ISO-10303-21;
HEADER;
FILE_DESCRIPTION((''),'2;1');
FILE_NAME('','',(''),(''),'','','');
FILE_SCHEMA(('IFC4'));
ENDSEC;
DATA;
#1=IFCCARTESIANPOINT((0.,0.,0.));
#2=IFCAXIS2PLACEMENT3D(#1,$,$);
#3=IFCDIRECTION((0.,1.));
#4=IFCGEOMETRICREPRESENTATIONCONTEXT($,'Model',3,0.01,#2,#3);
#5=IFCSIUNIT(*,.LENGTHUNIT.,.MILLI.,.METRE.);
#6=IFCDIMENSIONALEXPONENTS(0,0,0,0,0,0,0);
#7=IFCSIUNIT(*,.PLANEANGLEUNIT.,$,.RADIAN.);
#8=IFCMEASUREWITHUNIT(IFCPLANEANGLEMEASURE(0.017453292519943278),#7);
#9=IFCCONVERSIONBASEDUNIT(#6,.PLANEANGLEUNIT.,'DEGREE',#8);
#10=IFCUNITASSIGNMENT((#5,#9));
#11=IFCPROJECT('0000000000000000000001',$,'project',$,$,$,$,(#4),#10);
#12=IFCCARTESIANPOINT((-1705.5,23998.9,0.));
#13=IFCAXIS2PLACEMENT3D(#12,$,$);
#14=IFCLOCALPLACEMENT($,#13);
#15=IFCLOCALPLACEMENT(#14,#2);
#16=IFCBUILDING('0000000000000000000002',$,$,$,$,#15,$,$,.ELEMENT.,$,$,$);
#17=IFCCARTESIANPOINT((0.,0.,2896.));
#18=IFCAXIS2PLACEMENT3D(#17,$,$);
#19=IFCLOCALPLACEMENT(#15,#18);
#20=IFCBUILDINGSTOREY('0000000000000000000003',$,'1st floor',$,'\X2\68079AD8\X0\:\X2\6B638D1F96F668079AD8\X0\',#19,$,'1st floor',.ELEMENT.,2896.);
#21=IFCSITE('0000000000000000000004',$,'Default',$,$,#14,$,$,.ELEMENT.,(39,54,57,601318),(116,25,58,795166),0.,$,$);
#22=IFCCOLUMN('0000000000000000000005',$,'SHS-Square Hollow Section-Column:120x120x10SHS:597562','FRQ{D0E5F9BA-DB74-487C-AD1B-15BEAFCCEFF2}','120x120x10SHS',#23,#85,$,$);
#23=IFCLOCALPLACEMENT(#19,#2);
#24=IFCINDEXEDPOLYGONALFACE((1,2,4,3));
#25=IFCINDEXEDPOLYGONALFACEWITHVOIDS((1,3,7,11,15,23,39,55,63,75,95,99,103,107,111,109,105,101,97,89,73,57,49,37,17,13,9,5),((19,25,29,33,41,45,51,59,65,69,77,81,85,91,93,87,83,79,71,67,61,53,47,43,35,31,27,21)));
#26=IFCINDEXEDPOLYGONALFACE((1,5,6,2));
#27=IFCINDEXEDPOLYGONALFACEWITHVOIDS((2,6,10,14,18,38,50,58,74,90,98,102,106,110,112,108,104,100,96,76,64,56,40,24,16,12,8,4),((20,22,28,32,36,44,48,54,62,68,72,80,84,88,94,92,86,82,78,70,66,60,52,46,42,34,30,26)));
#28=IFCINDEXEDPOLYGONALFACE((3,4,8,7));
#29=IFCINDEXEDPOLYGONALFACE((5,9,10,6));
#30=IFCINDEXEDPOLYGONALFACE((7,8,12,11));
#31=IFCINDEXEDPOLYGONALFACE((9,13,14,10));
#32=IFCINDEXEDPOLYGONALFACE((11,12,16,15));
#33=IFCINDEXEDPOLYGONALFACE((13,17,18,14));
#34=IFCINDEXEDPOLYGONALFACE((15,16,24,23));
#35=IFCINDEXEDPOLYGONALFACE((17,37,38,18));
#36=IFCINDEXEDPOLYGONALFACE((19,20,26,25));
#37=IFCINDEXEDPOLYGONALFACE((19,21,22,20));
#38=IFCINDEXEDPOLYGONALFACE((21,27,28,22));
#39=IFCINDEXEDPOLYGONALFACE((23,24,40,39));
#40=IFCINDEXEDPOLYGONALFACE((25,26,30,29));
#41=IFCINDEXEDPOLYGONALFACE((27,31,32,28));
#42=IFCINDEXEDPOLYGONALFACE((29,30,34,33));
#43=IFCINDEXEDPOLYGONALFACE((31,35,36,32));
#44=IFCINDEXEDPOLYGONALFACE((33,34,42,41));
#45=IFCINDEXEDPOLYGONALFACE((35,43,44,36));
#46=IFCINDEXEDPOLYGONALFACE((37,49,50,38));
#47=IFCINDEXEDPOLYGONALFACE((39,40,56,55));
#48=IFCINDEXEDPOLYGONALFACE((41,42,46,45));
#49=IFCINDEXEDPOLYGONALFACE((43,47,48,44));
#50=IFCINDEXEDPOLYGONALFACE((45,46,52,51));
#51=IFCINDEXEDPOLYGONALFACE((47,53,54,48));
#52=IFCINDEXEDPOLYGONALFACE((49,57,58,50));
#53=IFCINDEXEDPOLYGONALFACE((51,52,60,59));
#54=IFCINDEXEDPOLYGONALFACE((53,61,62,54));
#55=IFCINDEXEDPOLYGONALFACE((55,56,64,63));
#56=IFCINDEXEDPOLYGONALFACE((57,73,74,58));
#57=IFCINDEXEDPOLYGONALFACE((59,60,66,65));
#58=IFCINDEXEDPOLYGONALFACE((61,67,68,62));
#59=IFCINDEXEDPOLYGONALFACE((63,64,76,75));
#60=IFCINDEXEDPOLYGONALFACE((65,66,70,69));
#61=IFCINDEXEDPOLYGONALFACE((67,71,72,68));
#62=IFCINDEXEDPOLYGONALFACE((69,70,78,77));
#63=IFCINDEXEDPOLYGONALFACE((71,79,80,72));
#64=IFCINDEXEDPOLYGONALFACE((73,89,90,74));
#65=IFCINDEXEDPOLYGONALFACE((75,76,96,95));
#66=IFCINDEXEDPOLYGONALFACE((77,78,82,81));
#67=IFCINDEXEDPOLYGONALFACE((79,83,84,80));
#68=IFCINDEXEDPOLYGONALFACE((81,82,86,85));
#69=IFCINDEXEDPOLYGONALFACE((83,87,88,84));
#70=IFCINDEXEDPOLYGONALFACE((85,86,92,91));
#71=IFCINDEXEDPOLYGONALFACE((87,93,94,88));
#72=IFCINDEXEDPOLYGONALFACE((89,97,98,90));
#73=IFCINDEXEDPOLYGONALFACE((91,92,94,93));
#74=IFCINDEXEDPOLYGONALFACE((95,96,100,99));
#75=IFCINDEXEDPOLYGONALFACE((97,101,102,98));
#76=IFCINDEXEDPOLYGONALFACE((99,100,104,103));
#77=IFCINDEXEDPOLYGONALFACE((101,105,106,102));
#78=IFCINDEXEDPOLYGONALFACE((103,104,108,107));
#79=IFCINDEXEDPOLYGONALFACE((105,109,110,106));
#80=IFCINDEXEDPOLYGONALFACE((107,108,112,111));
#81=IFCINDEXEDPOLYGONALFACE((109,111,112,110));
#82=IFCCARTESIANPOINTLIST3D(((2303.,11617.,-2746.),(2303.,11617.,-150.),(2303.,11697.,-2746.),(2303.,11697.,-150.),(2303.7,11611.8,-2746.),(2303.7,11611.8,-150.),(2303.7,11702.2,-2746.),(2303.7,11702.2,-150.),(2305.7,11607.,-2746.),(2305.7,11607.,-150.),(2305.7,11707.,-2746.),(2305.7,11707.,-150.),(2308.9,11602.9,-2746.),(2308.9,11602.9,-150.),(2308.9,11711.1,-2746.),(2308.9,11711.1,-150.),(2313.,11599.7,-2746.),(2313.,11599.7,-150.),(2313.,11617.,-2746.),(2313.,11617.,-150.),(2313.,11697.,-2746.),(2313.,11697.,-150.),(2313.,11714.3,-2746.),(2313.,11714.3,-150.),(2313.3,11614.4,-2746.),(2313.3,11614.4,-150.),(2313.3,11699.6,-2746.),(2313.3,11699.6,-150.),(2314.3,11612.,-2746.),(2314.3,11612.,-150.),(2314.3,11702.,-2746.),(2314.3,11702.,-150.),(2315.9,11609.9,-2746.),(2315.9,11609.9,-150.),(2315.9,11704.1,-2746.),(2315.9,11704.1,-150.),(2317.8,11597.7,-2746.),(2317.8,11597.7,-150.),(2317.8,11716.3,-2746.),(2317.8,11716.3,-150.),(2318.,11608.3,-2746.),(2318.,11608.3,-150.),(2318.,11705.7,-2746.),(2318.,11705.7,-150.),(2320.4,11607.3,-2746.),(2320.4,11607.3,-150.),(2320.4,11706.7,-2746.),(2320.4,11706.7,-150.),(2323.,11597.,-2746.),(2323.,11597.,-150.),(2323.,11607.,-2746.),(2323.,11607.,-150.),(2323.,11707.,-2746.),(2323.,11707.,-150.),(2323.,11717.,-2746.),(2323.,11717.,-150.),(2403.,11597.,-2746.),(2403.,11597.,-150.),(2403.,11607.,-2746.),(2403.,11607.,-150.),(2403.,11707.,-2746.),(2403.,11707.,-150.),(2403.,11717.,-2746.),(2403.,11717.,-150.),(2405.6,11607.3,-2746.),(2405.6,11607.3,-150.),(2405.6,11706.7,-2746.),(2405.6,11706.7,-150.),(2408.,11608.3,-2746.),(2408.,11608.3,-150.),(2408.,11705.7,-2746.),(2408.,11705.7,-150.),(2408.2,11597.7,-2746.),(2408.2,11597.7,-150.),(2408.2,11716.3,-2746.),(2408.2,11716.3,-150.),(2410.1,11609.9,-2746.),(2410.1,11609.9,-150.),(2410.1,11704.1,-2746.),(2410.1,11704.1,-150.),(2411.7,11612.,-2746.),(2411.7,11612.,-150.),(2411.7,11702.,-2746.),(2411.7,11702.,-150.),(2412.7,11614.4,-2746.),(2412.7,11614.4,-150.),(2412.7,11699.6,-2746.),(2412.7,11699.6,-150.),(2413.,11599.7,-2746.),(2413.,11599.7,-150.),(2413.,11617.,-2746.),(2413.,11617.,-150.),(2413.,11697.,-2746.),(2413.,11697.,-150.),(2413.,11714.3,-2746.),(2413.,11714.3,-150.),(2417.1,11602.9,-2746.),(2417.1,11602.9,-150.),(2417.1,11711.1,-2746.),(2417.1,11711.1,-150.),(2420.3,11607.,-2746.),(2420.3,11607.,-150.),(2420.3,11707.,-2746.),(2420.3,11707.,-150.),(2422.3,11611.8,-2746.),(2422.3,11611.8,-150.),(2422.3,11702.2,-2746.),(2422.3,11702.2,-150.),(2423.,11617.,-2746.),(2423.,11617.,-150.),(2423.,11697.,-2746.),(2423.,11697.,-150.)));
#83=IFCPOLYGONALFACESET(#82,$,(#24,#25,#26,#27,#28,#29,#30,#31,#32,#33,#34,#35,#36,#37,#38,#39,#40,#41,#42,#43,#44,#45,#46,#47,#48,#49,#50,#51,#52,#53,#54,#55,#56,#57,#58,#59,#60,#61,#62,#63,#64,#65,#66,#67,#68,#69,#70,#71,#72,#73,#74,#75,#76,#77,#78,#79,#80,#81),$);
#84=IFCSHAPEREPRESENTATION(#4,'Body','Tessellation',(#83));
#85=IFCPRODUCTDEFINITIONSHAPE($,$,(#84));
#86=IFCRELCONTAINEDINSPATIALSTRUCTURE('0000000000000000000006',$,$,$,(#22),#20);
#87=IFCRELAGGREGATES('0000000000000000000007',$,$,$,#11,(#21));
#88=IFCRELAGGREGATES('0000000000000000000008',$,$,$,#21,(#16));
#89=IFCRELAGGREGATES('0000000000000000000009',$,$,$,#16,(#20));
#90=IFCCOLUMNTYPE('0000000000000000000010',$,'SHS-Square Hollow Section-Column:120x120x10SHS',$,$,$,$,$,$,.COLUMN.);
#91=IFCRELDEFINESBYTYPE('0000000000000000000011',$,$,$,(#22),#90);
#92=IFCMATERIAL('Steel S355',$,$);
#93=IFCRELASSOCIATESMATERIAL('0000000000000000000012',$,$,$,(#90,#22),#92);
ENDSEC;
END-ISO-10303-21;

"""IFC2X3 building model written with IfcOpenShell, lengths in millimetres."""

from ifc_helpers import new_model, entity, si_unit, converted_unit, direction, frame, origin, origin_2d, place, context, project, spatial, hollow_rectangle, extrude, clip, halfspace, material, type_object, element, save


model = new_model("IFC2X3")

# Units and contexts
model_context = context("Model", 3, precision=0.01, world=origin(), true_north=direction((0.0, 1.0)))
ifc_project = project(units=[si_unit("LENGTHUNIT", "METRE", prefix="MILLI"), converted_unit("PLANEANGLEUNIT", "DEGREE", entity("IfcPlaneAngleMeasure", 0.017453292519943278), si_unit("PLANEANGLEUNIT", "RADIAN"), dimensions=[0, 0, 0, 0, 0, 0, 0])], contexts=[model_context])

# Site, building, storey
site_placement = place(None, frame((-1705.5, 23998.9, 0.0)))
site = spatial("IfcSite", under=ifc_project, at=site_placement, Name="Default", CompositionType="ELEMENT", RefLatitude=(39, 54, 57, 601318), RefLongitude=(116, 25, 58, 795166), RefElevation=0.0)
building_placement = place(site_placement, origin())
building = spatial("IfcBuilding", under=site, at=building_placement, CompositionType="ELEMENT")
storey_placement = place(building_placement, frame((0.0, 0.0, 2896.0)))
storey = spatial("IfcBuildingStorey", under=building, at=storey_placement, Name="1st floor", ObjectType="标高:正负零标高", LongName="1st floor", CompositionType="ELEMENT", Elevation=2896.0)

# Shared definitions
ifc_material_1 = material(Name="Steel S355")

# Column
column_type_1 = type_object("IfcColumnType", Name="SHS-Square Hollow Section-Column:120x120x10SHS", PredefinedType="COLUMN", material=ifc_material_1)
column_1_placement = place(storey_placement, frame((2363.0, 11657.0, -65.1), z_axis=(0.0, 0.0, 1.0), x_axis=(0.0, -1.0, 0.0)))
element("IfcColumn", 1, at=column_1_placement, inside=storey, type_object=column_type_1, material=ifc_material_1, Name="SHS-Square Hollow Section-Column:120x120x10SHS:597562", Description="FRQ{D0E5F9BA-DB74-487C-AD1B-15BEAFCCEFF2}", ObjectType="120x120x10SHS", context=model_context, shape_type="Clipping", body=[
    clip(clip(extrude(hollow_rectangle(XDim=120.0, YDim=120.0, WallThickness=10.0, InnerFilletRadius=10.0, OuterFilletRadius=20.0, at=origin_2d()), origin(), (0.0, 0.0, -1.0), 2765.7), halfspace(frame((11657.0, -2363.0, -84.9), z_axis=(0.0, 0.0, -1.0), x_axis=(0.0, -1.0, 0.0)), True)), halfspace(frame((11657.0, -2363.0, -2680.9), z_axis=(0.0, 0.0, 1.0), x_axis=(0.0, 1.0, 0.0)), True)),
])

save(model, "model.ifc")
